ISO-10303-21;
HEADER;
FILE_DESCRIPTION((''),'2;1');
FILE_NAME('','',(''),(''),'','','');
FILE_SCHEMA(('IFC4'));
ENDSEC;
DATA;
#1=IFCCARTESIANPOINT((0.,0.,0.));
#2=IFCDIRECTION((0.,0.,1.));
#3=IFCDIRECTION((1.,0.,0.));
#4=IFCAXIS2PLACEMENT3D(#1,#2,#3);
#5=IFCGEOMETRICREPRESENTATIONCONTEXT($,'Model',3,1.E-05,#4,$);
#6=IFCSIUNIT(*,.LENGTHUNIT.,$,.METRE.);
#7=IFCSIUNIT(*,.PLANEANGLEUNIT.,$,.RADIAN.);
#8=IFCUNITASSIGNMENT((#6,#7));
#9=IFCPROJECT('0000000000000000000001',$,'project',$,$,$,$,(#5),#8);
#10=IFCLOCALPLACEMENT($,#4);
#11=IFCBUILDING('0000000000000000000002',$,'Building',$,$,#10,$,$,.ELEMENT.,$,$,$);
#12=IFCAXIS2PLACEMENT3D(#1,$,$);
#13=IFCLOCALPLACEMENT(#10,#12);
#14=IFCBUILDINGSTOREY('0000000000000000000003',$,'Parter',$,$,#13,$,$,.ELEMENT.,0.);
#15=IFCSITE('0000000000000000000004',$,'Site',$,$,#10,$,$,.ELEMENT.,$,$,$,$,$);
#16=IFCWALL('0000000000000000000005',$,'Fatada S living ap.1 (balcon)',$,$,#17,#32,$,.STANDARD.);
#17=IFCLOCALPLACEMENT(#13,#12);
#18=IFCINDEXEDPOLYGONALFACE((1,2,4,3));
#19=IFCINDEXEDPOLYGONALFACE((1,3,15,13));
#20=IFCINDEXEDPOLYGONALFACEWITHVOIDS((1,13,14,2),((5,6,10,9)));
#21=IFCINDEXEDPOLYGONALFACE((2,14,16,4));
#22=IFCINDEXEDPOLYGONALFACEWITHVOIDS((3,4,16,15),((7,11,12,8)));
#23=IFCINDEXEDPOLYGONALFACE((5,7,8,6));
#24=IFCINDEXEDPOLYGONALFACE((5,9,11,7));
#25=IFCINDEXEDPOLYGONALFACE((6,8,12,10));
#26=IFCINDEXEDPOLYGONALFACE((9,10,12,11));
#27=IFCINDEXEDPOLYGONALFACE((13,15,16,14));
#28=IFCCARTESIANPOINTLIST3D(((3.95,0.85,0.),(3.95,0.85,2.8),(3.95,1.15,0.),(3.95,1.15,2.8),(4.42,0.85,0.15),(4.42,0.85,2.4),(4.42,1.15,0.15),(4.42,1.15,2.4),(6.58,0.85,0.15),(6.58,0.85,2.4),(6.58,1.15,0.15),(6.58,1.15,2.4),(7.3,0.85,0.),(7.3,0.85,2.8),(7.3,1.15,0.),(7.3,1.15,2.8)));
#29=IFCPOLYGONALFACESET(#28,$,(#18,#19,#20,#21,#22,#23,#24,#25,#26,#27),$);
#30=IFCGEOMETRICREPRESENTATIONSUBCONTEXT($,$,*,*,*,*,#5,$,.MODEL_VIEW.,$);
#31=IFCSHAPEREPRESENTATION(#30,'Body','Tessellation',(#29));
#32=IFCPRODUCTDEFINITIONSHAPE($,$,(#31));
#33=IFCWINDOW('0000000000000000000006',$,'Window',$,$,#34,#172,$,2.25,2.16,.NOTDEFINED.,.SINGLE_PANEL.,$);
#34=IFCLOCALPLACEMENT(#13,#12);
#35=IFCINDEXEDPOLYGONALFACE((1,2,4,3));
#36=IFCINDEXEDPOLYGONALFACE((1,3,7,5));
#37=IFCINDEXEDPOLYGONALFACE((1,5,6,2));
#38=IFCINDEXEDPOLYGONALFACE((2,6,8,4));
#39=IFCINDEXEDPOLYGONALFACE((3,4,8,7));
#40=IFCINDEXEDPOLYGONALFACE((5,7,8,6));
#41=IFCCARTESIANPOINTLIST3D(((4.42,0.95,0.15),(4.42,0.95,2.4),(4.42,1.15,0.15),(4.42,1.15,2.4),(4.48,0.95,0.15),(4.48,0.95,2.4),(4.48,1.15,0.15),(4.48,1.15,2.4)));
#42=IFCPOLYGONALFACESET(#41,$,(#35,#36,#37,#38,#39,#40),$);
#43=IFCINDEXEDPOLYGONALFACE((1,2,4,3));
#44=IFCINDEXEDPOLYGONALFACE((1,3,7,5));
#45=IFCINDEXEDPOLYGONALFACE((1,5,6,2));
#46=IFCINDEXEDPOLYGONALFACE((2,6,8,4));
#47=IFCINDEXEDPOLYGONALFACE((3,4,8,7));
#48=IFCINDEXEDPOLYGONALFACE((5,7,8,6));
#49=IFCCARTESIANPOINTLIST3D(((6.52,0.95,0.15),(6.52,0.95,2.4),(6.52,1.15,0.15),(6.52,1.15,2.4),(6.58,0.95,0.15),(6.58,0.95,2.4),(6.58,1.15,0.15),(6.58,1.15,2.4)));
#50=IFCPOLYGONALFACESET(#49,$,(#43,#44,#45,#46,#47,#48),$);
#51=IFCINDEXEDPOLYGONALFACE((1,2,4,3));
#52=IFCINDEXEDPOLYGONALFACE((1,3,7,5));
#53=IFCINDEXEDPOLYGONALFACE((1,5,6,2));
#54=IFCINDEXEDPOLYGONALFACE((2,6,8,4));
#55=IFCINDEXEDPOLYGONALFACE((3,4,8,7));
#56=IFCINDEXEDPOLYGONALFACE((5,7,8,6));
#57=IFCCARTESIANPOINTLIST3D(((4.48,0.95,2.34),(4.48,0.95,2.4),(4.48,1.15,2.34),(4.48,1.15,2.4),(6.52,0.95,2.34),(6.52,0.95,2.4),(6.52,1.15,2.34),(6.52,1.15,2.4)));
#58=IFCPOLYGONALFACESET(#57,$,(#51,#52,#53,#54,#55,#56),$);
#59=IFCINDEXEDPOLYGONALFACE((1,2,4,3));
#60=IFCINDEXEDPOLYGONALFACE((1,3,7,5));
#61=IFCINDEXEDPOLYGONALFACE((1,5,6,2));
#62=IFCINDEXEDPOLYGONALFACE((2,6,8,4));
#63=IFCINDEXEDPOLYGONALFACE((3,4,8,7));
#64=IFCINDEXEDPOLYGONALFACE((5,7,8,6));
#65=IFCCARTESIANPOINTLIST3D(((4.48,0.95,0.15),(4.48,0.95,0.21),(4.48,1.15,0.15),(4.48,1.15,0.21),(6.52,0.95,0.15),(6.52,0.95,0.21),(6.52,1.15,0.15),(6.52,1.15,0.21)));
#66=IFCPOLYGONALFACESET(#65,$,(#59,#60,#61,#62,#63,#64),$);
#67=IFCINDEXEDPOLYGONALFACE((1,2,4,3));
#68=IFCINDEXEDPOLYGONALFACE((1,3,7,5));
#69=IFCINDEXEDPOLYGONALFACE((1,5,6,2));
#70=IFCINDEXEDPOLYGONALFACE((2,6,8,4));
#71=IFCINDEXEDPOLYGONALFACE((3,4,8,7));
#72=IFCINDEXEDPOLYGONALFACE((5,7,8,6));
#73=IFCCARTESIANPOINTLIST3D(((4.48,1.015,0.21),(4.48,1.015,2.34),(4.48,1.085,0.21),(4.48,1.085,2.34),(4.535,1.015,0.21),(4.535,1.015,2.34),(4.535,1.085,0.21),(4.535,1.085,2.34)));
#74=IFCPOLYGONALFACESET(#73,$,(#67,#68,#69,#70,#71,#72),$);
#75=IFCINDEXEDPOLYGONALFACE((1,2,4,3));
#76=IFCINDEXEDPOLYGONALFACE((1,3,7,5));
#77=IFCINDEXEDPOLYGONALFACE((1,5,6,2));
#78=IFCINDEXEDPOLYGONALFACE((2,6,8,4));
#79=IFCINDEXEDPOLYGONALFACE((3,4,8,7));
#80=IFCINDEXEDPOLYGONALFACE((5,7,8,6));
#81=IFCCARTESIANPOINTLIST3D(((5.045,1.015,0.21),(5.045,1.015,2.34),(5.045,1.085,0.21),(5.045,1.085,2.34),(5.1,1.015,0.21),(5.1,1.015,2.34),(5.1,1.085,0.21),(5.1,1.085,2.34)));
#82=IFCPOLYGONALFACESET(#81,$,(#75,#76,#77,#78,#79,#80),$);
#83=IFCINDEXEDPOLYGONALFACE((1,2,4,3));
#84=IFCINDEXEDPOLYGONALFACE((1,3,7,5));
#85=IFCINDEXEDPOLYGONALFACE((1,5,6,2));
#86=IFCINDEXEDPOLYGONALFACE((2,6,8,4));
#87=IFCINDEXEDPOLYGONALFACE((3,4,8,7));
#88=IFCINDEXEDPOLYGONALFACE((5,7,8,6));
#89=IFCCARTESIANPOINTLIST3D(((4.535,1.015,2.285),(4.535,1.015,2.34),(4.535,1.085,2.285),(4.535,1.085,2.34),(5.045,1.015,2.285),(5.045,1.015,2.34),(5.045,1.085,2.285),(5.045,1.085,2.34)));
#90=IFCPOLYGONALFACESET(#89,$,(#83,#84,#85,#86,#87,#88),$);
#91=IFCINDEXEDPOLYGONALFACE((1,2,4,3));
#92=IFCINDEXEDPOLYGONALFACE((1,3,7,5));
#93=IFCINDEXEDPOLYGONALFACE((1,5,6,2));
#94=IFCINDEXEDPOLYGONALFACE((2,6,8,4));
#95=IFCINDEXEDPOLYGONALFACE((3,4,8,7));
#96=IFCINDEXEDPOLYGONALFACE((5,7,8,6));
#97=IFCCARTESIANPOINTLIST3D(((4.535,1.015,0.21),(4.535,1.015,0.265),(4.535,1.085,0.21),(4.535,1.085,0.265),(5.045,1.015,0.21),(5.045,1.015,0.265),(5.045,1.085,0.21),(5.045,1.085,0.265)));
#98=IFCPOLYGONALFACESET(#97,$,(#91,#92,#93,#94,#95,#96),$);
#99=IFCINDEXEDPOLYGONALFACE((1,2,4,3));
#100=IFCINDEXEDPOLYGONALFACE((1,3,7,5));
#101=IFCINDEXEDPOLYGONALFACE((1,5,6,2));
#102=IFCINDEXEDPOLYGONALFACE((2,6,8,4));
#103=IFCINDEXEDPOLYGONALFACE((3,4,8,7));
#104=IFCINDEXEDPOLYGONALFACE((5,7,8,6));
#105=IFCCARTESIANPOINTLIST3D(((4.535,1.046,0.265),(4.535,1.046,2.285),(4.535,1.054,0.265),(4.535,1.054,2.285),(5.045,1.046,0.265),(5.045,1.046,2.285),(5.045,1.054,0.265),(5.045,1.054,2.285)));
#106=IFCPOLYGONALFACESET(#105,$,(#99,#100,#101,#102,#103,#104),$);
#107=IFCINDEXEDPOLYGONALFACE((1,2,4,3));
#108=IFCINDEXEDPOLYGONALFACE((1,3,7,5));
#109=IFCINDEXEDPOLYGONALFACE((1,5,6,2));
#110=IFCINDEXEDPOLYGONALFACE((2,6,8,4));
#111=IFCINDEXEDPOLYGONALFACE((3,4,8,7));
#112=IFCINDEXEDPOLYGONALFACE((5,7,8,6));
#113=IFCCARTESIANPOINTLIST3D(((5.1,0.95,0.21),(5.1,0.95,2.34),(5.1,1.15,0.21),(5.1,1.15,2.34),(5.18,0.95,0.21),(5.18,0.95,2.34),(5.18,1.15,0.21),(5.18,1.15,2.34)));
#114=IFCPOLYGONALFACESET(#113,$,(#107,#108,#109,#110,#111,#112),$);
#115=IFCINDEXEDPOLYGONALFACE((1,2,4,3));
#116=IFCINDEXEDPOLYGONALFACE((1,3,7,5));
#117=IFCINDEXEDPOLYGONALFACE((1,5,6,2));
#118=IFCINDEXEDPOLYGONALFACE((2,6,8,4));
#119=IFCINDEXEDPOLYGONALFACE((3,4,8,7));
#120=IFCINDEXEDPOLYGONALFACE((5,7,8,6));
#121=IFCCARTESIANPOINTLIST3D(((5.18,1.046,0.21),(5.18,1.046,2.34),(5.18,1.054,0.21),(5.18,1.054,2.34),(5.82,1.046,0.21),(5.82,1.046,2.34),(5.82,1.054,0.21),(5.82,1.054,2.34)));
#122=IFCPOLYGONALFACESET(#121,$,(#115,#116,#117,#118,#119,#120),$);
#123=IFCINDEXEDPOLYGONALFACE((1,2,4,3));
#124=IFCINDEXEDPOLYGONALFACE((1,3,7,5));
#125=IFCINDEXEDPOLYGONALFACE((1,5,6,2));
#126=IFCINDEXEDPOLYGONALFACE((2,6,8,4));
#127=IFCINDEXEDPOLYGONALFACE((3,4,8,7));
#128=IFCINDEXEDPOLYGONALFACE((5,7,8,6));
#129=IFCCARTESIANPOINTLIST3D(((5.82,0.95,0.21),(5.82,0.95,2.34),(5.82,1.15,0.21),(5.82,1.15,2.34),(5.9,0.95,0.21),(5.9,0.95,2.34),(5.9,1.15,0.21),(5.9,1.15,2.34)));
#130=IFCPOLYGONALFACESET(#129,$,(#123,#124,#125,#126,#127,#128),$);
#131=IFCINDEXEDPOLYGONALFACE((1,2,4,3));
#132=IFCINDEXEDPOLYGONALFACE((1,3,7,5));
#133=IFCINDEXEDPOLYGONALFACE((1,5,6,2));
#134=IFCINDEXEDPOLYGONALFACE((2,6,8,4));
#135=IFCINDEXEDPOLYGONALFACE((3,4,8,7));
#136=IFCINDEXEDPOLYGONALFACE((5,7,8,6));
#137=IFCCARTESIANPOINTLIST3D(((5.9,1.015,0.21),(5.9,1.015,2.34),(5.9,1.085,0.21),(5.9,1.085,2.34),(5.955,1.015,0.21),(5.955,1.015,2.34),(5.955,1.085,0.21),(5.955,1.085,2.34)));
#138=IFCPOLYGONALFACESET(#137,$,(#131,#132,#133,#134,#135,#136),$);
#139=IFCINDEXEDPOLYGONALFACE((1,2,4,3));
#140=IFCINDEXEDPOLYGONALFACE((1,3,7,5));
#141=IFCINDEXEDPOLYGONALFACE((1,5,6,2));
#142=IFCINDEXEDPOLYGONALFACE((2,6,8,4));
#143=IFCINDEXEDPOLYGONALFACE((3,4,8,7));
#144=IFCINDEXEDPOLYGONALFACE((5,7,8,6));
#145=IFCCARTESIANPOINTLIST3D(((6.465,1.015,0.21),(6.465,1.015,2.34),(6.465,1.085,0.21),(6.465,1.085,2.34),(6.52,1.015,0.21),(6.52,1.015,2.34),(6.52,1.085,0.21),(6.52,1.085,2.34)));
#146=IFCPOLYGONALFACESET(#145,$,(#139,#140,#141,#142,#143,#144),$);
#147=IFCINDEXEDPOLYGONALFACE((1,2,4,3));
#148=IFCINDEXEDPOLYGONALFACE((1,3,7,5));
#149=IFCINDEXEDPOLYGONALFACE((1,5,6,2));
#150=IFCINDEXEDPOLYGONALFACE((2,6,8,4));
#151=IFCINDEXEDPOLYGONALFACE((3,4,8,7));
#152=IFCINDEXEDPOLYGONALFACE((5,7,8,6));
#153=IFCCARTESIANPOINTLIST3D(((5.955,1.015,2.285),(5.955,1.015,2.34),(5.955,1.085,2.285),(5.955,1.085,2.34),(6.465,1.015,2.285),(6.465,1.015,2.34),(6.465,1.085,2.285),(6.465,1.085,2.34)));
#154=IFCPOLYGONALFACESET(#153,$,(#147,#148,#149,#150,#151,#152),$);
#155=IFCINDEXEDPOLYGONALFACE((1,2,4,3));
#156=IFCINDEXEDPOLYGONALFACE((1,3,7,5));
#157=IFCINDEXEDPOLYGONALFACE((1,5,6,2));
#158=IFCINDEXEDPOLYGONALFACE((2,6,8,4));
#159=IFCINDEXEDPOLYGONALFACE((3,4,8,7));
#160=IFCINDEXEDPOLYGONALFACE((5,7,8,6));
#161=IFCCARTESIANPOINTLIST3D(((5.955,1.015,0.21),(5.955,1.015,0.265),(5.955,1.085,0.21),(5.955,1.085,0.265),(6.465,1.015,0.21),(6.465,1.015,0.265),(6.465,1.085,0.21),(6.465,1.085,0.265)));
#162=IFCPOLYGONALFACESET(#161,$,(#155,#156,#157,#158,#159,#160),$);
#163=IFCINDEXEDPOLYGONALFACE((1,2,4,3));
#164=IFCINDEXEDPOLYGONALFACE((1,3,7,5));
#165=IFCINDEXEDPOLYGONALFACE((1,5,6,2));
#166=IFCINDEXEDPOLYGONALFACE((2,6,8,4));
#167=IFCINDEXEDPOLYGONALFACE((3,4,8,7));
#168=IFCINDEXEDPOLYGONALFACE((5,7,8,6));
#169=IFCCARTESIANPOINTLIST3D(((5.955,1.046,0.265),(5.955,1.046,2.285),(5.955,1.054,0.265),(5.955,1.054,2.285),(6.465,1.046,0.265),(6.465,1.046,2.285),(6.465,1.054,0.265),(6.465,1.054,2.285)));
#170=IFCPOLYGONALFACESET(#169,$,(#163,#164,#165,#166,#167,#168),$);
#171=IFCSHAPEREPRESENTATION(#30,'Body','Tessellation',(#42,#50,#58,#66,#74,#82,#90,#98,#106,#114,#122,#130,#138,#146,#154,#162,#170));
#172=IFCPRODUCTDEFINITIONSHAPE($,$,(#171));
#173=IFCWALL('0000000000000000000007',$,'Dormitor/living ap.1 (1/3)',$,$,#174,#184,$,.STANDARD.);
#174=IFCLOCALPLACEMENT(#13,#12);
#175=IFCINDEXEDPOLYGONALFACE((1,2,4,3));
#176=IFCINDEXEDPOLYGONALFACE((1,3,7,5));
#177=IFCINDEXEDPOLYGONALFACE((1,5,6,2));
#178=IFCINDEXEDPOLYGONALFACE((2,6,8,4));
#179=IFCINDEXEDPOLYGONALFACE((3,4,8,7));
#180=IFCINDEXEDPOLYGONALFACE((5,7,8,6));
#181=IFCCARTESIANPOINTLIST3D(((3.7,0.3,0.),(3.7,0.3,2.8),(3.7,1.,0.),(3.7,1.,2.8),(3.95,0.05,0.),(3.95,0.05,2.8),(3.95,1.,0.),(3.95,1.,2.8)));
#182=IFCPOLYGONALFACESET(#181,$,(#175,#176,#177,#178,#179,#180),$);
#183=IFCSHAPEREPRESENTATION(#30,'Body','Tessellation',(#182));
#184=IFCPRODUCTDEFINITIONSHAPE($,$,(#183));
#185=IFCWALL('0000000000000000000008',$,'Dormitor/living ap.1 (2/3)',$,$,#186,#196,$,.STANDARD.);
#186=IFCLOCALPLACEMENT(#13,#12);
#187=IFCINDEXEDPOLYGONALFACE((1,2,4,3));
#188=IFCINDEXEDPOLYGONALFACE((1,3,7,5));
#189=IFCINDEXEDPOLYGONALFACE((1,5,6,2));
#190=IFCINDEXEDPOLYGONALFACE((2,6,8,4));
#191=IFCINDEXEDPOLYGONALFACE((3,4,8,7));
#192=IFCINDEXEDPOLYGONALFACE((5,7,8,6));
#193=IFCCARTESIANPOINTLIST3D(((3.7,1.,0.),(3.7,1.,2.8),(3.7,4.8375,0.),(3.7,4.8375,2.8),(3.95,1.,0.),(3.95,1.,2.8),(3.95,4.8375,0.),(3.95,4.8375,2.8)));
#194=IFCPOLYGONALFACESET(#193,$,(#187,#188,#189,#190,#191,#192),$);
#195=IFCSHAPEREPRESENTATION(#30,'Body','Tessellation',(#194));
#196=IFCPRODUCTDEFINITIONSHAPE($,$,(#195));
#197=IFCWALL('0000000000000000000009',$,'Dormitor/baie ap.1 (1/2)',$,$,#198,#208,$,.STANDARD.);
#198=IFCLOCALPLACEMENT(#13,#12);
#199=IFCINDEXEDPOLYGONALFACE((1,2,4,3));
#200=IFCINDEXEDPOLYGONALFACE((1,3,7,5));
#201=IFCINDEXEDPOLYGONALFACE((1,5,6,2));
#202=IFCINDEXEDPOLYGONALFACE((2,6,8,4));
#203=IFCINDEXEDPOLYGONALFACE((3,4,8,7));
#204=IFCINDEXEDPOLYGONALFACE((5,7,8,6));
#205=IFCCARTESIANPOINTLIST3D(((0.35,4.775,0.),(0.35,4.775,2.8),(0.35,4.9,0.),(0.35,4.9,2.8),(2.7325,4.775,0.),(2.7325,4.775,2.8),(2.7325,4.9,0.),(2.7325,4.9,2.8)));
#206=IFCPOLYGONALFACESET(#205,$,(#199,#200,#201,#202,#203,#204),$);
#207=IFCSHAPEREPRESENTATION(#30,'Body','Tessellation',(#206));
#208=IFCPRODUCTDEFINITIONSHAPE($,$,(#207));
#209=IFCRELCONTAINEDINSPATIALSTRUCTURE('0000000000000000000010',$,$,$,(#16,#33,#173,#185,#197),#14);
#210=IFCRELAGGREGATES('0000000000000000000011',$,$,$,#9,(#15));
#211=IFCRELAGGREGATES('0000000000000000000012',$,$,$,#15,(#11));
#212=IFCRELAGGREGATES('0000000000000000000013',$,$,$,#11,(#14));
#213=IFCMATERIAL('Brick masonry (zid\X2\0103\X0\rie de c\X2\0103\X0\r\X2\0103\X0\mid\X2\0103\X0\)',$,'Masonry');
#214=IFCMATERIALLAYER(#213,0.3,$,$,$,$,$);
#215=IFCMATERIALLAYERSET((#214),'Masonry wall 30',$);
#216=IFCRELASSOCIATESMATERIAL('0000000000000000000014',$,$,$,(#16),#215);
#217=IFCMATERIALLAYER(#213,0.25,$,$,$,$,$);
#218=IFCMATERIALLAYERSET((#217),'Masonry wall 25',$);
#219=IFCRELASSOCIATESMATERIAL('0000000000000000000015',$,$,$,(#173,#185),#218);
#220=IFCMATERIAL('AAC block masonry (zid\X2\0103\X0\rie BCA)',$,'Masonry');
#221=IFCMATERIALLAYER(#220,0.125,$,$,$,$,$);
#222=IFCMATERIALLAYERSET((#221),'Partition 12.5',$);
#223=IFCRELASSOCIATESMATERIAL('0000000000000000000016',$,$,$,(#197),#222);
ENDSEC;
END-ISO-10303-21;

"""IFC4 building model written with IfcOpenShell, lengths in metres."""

from ifc_helpers import new_model, si_unit, frame, frame_2d, origin, origin_with_axes, origin_2d, place, context, subcontext, project, spatial, rectangle, extrude, clip, halfspace, material, layer, layer_set, layer_usage, element, fill, save


model = new_model("IFC4")

# Units and contexts
model_context = context("Model", 3, precision=1e-05, world=origin_with_axes())
sub_context = subcontext(model_context, None, None, "MODEL_VIEW")
ifc_project = project(units=[si_unit("LENGTHUNIT", "METRE"), si_unit("PLANEANGLEUNIT", "RADIAN")], contexts=[model_context])

# Site, building, storey
placement = place(None, origin_with_axes())
site = spatial("IfcSite", under=ifc_project, at=placement, Name="Site", CompositionType="ELEMENT")
building = spatial("IfcBuilding", under=site, at=placement, Name="Building", CompositionType="ELEMENT")
storey_placement = place(placement, origin())
storey = spatial("IfcBuildingStorey", under=building, at=storey_placement, Name="Parter", CompositionType="ELEMENT", Elevation=0.0)

# Wall, opening, window
ifc_material_1 = material(Name="Brick masonry (zidărie de cărămidă)", Category="Masonry")
ifc_layer_1 = layer(ifc_material_1, 0.3)
ifc_layer_set_1 = layer_set([ifc_layer_1], Name="Masonry wall 30")
ifc_layer_usage_1 = layer_usage(ifc_layer_set_1, "AXIS2", "POSITIVE", -0.15)
wall_1_placement = place(storey_placement, frame((3.95, 1.0, 0.0), x_axis=(1.0, 0.0, 0.0)))
wall_1 = element("IfcWall", 1, at=wall_1_placement, inside=storey, material=ifc_layer_usage_1, Name="Fatada S living ap.1 (balcon)", PredefinedType="STANDARD", context=sub_context, shape_type="SweptSolid", body=[
    extrude(rectangle(XDim=3.35, YDim=0.3, at=frame_2d((1.675, 0.0))), origin(), (0.0, 0.0, 1.0), 2.8),
])
opening_1_placement = place(wall_1_placement, frame((1.55, 0.2, 0.15), z_axis=(0.0, -1.0, 0.0), x_axis=(1.0, 0.0, 0.0)))
opening_1 = element("IfcOpeningElement", 2, at=opening_1_placement, cuts=wall_1, PredefinedType="OPENING", context=sub_context, shape_type="SweptSolid", body=[
    extrude(rectangle(XDim=2.16, YDim=2.25, at=frame_2d((0.0, 1.125))), origin(), (0.0, 0.0, 1.0), 0.4),
])
window_1_placement = place(wall_1_placement, frame((1.55, 0.15, 0.15), z_axis=(0.0, -1.0, 0.0), x_axis=(1.0, 0.0, 0.0)))
window_1 = element("IfcWindow", 3, at=window_1_placement, inside=storey, Name="Window", OverallHeight=2.25, OverallWidth=2.16, PartitioningType="SINGLE_PANEL", PredefinedType="NOTDEFINED", context=sub_context, shape_type="SweptSolid", body=[
    extrude(rectangle(XDim=0.06, YDim=2.25, at=origin_2d()), frame((-1.05, 1.125, 0.0)), (0.0, 0.0, 1.0), 0.2),
    extrude(rectangle(XDim=0.06, YDim=2.25, at=origin_2d()), frame((1.05, 1.125, 0.0)), (0.0, 0.0, 1.0), 0.2),
    extrude(rectangle(XDim=2.04, YDim=0.06, at=origin_2d()), frame((0.0, 2.22, 0.0)), (0.0, 0.0, 1.0), 0.2),
    extrude(rectangle(XDim=2.04, YDim=0.06, at=origin_2d()), frame((0.0, 0.03, 0.0)), (0.0, 0.0, 1.0), 0.2),
    extrude(rectangle(XDim=0.055, YDim=2.13, at=origin_2d()), frame((-0.9925, 1.125, 0.065)), (0.0, 0.0, 1.0), 0.07),
    extrude(rectangle(XDim=0.055, YDim=2.13, at=origin_2d()), frame((-0.4275, 1.125, 0.065)), (0.0, 0.0, 1.0), 0.07),
    extrude(rectangle(XDim=0.51, YDim=0.055, at=origin_2d()), frame((-0.71, 2.1625, 0.065)), (0.0, 0.0, 1.0), 0.07),
    extrude(rectangle(XDim=0.51, YDim=0.055, at=origin_2d()), frame((-0.71, 0.0875, 0.065)), (0.0, 0.0, 1.0), 0.07),
    extrude(rectangle(XDim=0.51, YDim=2.02, at=origin_2d()), frame((-0.71, 1.125, 0.096)), (0.0, 0.0, 1.0), 0.008),
    extrude(rectangle(XDim=0.08, YDim=2.13, at=origin_2d()), frame((-0.36, 1.125, 0.0)), (0.0, 0.0, 1.0), 0.2),
    extrude(rectangle(XDim=0.64, YDim=2.13, at=origin_2d()), frame((0.0, 1.125, 0.096)), (0.0, 0.0, 1.0), 0.008),
    extrude(rectangle(XDim=0.08, YDim=2.13, at=origin_2d()), frame((0.36, 1.125, 0.0)), (0.0, 0.0, 1.0), 0.2),
    extrude(rectangle(XDim=0.055, YDim=2.13, at=origin_2d()), frame((0.4275, 1.125, 0.065)), (0.0, 0.0, 1.0), 0.07),
    extrude(rectangle(XDim=0.055, YDim=2.13, at=origin_2d()), frame((0.9925, 1.125, 0.065)), (0.0, 0.0, 1.0), 0.07),
    extrude(rectangle(XDim=0.51, YDim=0.055, at=origin_2d()), frame((0.71, 2.1625, 0.065)), (0.0, 0.0, 1.0), 0.07),
    extrude(rectangle(XDim=0.51, YDim=0.055, at=origin_2d()), frame((0.71, 0.0875, 0.065)), (0.0, 0.0, 1.0), 0.07),
    extrude(rectangle(XDim=0.51, YDim=2.02, at=origin_2d()), frame((0.71, 1.125, 0.096)), (0.0, 0.0, 1.0), 0.008),
])
fill(opening_1, window_1)

# Walls
ifc_layer_2 = layer(ifc_material_1, 0.25)
ifc_layer_set_2 = layer_set([ifc_layer_2], Name="Masonry wall 25")
ifc_layer_usage_2 = layer_usage(ifc_layer_set_2, "AXIS2", "POSITIVE", -0.125)
wall_2_placement = place(storey_placement, frame((3.825, 0.05, 0.0), x_axis=(0.0, 1.0, 0.0)))
element("IfcWall", 4, at=wall_2_placement, inside=storey, material=ifc_layer_usage_2, Name="Dormitor/living ap.1 (1/3)", PredefinedType="STANDARD", context=sub_context, shape_type="CSG", body=[
    clip(extrude(rectangle(XDim=0.95, YDim=0.25, at=frame_2d((0.475, 0.0))), origin(), (0.0, 0.0, 1.0), 2.8), halfspace(frame((0.125, 0.0, 0.0), z_axis=(-0.707107, 0.707107, 0.0)), False)),
])
wall_3_placement = place(storey_placement, frame((3.825, 1.0, 0.0), x_axis=(0.0, 1.0, 0.0)))
element("IfcWall", 5, at=wall_3_placement, inside=storey, material=ifc_layer_usage_2, Name="Dormitor/living ap.1 (2/3)", PredefinedType="STANDARD", context=sub_context, shape_type="SweptSolid", body=[
    extrude(rectangle(XDim=3.8375, YDim=0.25, at=frame_2d((1.9188, 0.0))), origin(), (0.0, 0.0, 1.0), 2.8),
])
ifc_material_2 = material(Name="AAC block masonry (zidărie BCA)", Category="Masonry")
ifc_layer_3 = layer(ifc_material_2, 0.125)
ifc_layer_set_3 = layer_set([ifc_layer_3], Name="Partition 12.5")
ifc_layer_usage_3 = layer_usage(ifc_layer_set_3, "AXIS2", "POSITIVE", -0.0625)
wall_4_placement = place(storey_placement, frame((0.35, 4.8375, 0.0), x_axis=(1.0, 0.0, 0.0)))
element("IfcWall", 6, at=wall_4_placement, inside=storey, material=ifc_layer_usage_3, Name="Dormitor/baie ap.1 (1/2)", PredefinedType="STANDARD", context=sub_context, shape_type="SweptSolid", body=[
    extrude(rectangle(XDim=2.3825, YDim=0.125, at=frame_2d((1.1912, 0.0))), origin(), (0.0, 0.0, 1.0), 2.8),
])

save(model, "model.ifc")
